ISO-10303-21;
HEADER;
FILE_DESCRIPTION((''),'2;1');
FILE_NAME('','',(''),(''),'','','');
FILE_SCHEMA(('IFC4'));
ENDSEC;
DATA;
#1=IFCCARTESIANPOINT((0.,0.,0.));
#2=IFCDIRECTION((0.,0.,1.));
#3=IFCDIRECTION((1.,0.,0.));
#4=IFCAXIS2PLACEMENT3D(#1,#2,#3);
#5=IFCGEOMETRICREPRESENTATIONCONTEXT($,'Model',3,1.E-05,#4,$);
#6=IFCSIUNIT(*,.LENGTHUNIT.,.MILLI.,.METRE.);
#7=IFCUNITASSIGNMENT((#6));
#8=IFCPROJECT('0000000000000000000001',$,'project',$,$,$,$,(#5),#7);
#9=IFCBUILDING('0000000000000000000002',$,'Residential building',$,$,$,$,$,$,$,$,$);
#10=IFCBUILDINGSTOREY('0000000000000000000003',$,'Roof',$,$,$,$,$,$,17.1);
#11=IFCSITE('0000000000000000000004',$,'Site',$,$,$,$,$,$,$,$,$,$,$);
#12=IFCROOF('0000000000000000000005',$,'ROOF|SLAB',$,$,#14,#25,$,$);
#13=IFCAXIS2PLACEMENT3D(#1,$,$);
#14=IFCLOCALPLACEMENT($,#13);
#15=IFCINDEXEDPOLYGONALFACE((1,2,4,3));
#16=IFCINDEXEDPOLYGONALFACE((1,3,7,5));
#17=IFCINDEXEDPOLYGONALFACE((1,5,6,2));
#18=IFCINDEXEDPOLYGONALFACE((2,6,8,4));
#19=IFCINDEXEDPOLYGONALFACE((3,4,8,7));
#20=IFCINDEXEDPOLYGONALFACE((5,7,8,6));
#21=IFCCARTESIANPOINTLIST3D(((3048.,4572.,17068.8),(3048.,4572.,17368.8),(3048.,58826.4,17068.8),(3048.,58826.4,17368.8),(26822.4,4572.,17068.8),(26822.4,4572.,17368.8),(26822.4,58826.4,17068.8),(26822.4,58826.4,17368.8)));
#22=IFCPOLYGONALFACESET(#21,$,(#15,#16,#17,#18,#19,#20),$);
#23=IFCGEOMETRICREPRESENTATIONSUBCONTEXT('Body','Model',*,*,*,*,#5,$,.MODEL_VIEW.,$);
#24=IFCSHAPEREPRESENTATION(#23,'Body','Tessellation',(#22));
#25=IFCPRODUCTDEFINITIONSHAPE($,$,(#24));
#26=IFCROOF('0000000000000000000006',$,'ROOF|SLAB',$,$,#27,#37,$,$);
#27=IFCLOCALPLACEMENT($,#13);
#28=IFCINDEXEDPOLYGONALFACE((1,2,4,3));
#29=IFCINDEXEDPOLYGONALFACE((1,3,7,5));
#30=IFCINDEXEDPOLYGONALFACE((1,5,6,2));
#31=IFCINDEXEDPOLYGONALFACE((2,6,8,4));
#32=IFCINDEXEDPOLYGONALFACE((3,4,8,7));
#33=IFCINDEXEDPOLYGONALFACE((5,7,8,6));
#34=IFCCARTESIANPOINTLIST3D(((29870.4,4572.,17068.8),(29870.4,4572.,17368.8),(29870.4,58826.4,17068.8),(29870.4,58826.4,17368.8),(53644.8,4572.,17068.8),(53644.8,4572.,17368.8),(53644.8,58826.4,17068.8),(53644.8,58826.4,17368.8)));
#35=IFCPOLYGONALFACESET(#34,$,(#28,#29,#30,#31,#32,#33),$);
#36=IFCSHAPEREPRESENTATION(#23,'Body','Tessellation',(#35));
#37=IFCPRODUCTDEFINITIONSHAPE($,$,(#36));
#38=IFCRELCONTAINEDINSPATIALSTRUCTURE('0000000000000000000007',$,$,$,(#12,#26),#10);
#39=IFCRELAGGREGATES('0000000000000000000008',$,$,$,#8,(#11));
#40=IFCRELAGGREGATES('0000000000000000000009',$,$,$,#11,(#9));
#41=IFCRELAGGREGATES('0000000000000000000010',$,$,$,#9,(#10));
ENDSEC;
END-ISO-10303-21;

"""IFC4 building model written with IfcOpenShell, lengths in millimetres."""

from ifc_helpers import new_model, si_unit, frame, origin_with_axes, place, context, subcontext, project, spatial, indexed_curve, outline, extrude, element, save


model = new_model("IFC4")

# Units and contexts
model_context = context("Model", 3, precision=1e-05, world=origin_with_axes())
body_context = subcontext(model_context, "Body", "Model", "MODEL_VIEW")
ifc_project = project(units=[si_unit("LENGTHUNIT", "METRE", prefix="MILLI")], contexts=[model_context])

# Site, building, storey
site = spatial("IfcSite", under=ifc_project, Name="Site")
building = spatial("IfcBuilding", under=site, Name="Residential building")
storey = spatial("IfcBuildingStorey", under=building, Name="Roof", Elevation=17.1)

# Roofs
for number, where, z_axis, x_axis, name in (
    (1, (3048.0, 4572.0, 17068.8), (0.0, 0.0, 1.0), (1.0, 0.0, 0.0), "ROOF|SLAB"),
    (2, (29870.4, 4572.0, 17068.8), (0.0, 0.0, 1.0), (1.0, 0.0, 0.0), "ROOF|SLAB"),
):
    element("IfcRoof", number, at=place(None, frame(where, z_axis=z_axis, x_axis=x_axis)), inside=storey, Name=name, context=body_context, shape_type="SweptSolid", body=[
        extrude(outline(indexed_curve([(0.0, 0.0), (23774.4, 0.0), (23774.4, 54254.4), (0.0, 54254.4), (0.0, 0.0)])), None, (0.0, 0.0, 1.0), 300.0),
    ])

save(model, "model.ifc")
